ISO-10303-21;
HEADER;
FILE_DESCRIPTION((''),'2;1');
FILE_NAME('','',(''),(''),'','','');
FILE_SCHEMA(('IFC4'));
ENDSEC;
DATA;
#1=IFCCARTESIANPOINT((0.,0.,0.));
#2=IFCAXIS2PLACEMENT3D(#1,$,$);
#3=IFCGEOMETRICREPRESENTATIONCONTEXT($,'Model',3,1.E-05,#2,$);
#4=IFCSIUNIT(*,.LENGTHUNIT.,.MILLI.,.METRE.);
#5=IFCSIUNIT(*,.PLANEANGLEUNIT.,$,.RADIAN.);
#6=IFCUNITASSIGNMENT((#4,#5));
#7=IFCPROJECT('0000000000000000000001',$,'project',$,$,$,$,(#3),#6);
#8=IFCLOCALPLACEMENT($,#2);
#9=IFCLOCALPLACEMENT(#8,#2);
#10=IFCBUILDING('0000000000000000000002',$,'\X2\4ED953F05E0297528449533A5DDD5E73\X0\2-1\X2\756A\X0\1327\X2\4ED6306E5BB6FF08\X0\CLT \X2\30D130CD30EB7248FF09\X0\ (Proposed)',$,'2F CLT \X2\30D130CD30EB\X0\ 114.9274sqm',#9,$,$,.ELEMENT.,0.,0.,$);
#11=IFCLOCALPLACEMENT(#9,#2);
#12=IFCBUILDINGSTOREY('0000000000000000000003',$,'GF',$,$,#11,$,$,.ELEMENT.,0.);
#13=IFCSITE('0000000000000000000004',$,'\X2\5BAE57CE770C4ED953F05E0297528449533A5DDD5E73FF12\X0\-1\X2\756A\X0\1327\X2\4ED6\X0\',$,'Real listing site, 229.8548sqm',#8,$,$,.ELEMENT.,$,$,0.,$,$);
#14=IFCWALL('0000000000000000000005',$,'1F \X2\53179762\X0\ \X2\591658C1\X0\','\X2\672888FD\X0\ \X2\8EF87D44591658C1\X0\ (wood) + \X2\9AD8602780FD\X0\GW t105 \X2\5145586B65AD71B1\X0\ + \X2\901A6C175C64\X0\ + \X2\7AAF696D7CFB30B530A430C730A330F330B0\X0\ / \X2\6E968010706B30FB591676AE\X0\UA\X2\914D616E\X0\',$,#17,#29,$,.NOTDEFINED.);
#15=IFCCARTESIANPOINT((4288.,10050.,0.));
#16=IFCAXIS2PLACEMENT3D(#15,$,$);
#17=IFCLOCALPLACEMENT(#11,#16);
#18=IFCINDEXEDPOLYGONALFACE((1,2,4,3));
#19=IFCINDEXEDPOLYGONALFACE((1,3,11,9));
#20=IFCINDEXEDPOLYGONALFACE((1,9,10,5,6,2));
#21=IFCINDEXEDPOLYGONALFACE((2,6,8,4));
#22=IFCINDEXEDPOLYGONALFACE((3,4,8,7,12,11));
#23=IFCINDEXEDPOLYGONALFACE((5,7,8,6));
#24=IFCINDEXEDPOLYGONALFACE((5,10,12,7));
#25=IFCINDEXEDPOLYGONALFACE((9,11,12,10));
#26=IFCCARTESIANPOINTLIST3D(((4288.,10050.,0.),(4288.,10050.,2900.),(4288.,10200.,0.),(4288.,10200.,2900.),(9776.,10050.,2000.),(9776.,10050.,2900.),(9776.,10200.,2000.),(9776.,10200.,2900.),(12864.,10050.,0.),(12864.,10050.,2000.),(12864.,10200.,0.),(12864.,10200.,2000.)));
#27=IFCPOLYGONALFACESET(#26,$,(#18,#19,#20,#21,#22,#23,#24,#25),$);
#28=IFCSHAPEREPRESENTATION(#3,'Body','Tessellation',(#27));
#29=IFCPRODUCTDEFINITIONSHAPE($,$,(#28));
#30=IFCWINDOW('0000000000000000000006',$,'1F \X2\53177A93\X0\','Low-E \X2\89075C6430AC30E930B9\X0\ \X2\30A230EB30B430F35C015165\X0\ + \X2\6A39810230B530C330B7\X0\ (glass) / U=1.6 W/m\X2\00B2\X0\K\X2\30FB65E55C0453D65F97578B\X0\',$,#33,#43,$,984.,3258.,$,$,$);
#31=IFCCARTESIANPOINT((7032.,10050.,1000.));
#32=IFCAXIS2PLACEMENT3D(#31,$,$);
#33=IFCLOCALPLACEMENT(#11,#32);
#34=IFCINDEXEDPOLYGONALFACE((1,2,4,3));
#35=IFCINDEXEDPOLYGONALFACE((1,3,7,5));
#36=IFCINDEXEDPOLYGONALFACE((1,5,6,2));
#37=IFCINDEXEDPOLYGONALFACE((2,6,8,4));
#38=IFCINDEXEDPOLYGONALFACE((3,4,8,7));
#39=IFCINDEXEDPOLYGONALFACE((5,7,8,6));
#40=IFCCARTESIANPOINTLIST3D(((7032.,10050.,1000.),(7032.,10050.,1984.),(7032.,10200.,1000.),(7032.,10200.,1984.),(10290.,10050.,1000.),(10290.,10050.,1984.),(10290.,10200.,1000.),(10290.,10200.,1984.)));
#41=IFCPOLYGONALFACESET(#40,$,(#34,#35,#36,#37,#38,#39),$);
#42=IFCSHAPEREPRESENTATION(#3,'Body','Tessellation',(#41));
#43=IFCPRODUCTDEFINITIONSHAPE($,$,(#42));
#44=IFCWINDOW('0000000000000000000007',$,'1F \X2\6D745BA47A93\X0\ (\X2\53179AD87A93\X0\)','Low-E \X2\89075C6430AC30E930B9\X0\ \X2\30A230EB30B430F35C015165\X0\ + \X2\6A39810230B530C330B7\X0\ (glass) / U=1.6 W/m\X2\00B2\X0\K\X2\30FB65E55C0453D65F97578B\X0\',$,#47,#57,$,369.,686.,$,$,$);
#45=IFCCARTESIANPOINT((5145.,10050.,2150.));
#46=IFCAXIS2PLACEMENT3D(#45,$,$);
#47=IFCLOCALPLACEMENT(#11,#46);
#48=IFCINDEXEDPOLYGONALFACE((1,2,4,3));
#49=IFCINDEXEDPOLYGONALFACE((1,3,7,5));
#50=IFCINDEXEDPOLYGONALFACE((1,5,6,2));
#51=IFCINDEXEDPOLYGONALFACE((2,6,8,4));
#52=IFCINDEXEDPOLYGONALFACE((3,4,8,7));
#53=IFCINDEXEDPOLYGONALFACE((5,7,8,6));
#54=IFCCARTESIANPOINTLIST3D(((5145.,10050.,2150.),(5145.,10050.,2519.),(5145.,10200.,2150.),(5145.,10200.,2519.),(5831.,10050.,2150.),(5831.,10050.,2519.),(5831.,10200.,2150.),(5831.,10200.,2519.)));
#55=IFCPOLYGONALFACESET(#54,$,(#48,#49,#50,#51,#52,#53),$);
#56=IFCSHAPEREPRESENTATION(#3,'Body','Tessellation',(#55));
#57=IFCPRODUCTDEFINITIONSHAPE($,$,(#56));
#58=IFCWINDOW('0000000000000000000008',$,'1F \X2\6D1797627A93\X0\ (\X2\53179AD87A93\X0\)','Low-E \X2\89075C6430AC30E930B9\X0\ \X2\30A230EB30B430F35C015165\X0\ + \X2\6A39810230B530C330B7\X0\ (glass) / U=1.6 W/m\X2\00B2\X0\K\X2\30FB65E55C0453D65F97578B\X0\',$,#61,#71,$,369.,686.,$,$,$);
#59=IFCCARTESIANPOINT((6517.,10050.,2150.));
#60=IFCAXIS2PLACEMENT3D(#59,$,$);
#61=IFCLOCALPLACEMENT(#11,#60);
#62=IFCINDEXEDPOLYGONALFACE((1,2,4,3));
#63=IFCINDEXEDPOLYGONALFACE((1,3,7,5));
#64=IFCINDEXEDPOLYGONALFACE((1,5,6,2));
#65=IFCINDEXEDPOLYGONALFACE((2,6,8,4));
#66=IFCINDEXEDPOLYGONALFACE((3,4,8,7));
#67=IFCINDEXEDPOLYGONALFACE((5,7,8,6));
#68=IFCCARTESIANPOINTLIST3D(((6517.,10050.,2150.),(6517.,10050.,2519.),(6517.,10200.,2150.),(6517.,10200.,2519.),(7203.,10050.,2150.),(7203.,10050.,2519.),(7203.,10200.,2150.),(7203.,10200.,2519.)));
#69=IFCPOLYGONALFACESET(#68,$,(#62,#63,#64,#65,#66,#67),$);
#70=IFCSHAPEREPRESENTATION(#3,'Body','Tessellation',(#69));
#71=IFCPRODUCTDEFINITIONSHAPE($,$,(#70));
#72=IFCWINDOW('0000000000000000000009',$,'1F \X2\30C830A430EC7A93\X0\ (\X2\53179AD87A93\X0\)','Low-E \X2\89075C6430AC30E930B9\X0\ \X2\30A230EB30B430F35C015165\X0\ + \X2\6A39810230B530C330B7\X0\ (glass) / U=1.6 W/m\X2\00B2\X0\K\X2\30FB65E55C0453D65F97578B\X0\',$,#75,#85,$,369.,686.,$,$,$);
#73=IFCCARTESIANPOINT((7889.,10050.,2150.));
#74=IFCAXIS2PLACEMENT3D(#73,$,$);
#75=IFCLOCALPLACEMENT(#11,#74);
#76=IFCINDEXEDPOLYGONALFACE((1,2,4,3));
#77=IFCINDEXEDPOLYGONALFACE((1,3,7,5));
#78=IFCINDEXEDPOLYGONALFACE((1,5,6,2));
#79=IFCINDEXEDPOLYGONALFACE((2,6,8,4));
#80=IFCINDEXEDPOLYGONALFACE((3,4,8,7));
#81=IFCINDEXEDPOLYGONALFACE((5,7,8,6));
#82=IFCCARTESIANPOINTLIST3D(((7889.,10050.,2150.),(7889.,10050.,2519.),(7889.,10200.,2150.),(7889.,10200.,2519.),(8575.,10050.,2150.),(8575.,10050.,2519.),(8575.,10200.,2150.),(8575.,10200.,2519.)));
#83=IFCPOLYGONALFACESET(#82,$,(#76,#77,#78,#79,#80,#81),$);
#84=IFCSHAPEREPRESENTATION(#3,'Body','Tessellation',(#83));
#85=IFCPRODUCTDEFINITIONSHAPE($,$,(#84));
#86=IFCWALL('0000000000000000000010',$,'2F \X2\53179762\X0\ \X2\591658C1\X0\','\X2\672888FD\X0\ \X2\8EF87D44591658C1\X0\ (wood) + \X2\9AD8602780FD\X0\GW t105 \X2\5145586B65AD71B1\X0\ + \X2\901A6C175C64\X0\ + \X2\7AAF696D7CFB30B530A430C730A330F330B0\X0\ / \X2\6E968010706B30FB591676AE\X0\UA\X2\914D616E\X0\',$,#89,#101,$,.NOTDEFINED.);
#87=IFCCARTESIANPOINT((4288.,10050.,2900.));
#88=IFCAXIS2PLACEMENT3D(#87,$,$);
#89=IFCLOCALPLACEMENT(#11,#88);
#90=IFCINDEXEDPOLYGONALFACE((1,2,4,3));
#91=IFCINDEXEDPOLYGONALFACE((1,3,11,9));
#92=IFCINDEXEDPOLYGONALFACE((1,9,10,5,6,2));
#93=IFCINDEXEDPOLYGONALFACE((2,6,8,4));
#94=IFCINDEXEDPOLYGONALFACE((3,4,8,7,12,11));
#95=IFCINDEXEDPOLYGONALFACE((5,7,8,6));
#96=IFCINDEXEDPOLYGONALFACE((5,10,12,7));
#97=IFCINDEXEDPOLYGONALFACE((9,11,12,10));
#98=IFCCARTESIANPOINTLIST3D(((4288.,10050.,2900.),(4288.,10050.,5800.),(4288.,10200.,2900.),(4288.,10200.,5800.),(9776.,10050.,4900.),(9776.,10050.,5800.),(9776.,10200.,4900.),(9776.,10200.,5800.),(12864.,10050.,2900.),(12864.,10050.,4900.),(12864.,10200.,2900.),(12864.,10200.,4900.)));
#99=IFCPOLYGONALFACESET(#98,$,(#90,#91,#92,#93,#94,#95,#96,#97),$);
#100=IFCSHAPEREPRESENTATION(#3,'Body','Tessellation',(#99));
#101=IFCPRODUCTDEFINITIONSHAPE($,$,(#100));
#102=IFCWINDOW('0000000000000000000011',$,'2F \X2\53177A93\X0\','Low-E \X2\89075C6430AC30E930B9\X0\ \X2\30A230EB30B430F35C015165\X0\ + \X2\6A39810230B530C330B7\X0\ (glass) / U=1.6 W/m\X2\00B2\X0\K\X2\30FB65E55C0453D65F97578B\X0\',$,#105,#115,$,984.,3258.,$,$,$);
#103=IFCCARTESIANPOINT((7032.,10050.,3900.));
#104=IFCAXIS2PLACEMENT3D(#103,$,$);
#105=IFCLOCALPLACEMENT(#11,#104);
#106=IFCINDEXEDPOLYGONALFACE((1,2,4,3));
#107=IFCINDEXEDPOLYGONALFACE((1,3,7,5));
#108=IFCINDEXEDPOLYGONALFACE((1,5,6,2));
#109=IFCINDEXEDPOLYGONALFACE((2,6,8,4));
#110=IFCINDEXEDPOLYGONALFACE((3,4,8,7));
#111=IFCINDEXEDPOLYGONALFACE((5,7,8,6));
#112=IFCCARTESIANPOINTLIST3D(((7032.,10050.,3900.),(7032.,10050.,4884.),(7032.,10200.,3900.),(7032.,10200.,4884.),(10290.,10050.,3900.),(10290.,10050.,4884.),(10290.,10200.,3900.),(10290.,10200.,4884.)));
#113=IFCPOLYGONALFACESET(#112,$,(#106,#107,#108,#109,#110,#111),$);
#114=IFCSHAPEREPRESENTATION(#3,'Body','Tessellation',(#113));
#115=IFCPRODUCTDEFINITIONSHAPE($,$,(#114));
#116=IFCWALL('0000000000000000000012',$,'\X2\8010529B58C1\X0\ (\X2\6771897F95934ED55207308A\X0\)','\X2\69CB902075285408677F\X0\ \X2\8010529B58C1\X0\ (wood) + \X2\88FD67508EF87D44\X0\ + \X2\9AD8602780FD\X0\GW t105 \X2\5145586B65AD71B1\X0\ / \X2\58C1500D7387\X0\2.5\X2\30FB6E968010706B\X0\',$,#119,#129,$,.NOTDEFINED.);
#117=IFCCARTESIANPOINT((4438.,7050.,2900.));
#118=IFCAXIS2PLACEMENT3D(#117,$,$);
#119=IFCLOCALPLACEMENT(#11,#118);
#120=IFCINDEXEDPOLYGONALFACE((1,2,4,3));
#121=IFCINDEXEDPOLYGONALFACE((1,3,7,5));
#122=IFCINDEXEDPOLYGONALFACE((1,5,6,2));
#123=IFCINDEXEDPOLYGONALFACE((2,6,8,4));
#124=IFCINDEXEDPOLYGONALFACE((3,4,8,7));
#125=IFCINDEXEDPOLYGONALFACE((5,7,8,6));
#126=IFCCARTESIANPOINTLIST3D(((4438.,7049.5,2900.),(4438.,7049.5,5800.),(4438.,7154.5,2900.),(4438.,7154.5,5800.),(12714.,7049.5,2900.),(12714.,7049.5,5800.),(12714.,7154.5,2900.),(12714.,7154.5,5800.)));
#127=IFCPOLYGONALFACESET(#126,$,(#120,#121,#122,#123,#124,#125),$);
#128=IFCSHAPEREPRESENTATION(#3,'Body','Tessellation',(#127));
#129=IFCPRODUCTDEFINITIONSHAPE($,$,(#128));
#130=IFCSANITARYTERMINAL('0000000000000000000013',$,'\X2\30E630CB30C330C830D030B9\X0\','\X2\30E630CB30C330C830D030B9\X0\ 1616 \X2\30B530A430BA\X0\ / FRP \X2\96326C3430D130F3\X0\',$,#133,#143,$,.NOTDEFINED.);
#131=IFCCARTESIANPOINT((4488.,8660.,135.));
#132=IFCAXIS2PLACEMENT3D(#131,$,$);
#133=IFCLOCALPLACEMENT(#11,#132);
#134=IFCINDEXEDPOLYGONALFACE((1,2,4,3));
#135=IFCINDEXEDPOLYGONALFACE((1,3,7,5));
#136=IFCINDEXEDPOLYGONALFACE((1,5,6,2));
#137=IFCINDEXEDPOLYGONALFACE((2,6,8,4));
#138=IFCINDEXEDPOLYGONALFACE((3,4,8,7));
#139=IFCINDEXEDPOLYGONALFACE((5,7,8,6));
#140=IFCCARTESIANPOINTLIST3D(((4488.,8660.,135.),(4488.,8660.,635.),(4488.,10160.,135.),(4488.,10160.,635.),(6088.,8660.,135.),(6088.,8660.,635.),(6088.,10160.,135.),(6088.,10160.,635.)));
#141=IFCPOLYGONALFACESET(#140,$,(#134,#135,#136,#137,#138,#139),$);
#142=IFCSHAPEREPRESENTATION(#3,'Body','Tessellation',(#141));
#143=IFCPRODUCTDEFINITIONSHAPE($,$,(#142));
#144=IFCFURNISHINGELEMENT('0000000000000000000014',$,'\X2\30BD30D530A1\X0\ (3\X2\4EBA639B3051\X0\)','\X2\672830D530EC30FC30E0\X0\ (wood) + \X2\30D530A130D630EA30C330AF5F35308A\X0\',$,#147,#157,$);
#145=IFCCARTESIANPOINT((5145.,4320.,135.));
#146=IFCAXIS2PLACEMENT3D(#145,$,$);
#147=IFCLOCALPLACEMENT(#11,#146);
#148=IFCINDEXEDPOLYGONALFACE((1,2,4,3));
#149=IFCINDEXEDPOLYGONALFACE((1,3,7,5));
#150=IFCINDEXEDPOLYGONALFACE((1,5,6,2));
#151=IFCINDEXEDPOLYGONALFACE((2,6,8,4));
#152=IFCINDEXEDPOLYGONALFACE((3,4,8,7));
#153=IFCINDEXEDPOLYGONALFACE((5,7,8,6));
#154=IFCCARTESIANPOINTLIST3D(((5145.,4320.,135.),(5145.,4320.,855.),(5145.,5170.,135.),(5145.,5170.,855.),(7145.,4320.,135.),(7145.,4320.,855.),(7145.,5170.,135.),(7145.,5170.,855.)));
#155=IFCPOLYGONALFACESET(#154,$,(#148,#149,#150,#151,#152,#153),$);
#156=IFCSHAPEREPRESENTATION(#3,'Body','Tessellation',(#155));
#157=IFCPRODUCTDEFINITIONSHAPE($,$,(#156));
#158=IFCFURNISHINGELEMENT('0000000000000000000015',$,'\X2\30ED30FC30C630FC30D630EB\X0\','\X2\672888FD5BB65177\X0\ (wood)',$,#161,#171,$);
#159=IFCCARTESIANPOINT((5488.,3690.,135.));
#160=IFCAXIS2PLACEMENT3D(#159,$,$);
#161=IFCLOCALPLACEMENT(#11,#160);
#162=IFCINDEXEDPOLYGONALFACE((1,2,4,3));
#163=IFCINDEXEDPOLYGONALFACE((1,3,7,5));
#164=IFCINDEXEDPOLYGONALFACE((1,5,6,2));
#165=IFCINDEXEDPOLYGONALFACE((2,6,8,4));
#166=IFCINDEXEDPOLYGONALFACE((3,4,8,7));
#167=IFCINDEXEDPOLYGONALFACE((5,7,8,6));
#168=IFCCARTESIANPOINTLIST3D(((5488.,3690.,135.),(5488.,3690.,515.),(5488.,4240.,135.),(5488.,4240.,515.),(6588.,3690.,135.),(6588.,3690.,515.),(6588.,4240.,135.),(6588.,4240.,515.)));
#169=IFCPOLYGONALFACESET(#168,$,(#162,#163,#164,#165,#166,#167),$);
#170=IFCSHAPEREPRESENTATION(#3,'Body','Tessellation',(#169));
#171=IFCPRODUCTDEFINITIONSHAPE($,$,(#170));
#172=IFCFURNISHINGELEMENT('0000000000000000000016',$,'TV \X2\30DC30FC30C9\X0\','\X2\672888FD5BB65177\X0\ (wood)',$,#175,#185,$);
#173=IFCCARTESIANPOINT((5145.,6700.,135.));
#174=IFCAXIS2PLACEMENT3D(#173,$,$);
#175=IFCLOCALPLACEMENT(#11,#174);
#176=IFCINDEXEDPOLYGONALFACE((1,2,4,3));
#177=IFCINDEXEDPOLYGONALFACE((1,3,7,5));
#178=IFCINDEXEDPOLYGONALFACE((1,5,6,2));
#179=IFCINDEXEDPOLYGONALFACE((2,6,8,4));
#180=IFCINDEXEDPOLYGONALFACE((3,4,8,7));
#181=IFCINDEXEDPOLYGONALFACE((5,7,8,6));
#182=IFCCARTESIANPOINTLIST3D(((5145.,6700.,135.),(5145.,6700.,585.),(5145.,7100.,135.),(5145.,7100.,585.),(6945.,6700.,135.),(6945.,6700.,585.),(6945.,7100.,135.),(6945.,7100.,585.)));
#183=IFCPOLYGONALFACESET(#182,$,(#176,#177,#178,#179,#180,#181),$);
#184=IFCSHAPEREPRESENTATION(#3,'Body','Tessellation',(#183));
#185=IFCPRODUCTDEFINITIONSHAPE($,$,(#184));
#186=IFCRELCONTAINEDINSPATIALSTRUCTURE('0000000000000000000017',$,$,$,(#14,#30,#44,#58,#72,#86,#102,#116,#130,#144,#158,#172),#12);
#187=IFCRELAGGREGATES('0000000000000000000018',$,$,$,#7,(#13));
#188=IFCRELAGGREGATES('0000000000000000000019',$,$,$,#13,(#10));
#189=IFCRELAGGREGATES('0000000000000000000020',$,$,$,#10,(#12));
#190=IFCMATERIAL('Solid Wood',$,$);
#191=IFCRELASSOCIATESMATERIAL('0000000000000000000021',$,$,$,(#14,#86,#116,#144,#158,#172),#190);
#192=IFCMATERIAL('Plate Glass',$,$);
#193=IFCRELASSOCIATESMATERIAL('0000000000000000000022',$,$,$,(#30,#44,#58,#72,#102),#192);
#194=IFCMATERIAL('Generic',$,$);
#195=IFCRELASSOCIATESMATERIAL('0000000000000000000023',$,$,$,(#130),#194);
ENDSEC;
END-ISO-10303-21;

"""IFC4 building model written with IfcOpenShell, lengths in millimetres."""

from ifc_helpers import new_model, si_unit, frame, frame_2d, origin, place, context, project, spatial, rectangle, extrude, material, element, fill, save


model = new_model("IFC4")

# Units and contexts
model_context = context("Model", 3, precision=1e-05, world=origin())
ifc_project = project(units=[si_unit("LENGTHUNIT", "METRE", prefix="MILLI"), si_unit("PLANEANGLEUNIT", "RADIAN")], contexts=[model_context])

# Site, building, storey
site_placement = place(None, origin())
site = spatial("IfcSite", under=ifc_project, at=site_placement, Name="宮城県仙台市青葉区川平２-1番1327他", ObjectType="Real listing site, 229.8548sqm", CompositionType="ELEMENT", RefElevation=0.0)
building_placement = place(site_placement, origin())
building = spatial("IfcBuilding", under=site, at=building_placement, Name="仙台市青葉区川平2-1番1327他の家（CLT パネル版） (Proposed)", ObjectType="2F CLT パネル 114.9274sqm", CompositionType="ELEMENT", ElevationOfRefHeight=0.0, ElevationOfTerrain=0.0)
storey_placement = place(building_placement, origin())
storey = spatial("IfcBuildingStorey", under=building, at=storey_placement, Name="GF", CompositionType="ELEMENT", Elevation=0.0)

# Wall, openings, windows
ifc_material_1 = material(Name="Solid Wood")
wall_1_placement = place(storey_placement, frame((4288.0, 10050.0, 0.0)))
wall_1 = element("IfcWall", 1, at=wall_1_placement, inside=storey, material=ifc_material_1, Name="1F 北面 外壁", Description="木製 軸組外壁 (wood) + 高性能GW t105 充填断熱 + 通気層 + 窯業系サイディング / 準耐火・外皮UA配慮", PredefinedType="NOTDEFINED", context=model_context, shape_type="SweptSolid", body=[
    extrude(rectangle(XDim=8576.0, YDim=150.0, at=frame_2d((4288.0, 75.0))), frame((4288.0, 10050.0, 0.0)), (0.0, 0.0, 1.0), 2900.0),
])
opening_1_placement = place(storey_placement, frame((7032.0, 10050.0, 1000.0)))
opening_1 = element("IfcOpeningElement", 2, at=opening_1_placement, cuts=wall_1, PredefinedType="NOTDEFINED", context=model_context, shape_type="SweptSolid", body=[
    extrude(rectangle(XDim=3258.0, YDim=150.0, at=frame_2d((1629.0, 75.0))), frame((7032.0, 10050.0, 1000.0)), (0.0, 0.0, 1.0), 984.0),
])
opening_2_placement = place(storey_placement, frame((5145.0, 10050.0, 2150.0)))
opening_2 = element("IfcOpeningElement", 3, at=opening_2_placement, cuts=wall_1, PredefinedType="NOTDEFINED", context=model_context, shape_type="SweptSolid", body=[
    extrude(rectangle(XDim=686.0, YDim=150.0, at=frame_2d((343.0, 75.0))), frame((5145.0, 10050.0, 2150.0)), (0.0, 0.0, 1.0), 369.0),
])
opening_3_placement = place(storey_placement, frame((6517.0, 10050.0, 2150.0)))
opening_3 = element("IfcOpeningElement", 4, at=opening_3_placement, cuts=wall_1, PredefinedType="NOTDEFINED", context=model_context, shape_type="SweptSolid", body=[
    extrude(rectangle(XDim=686.0, YDim=150.0, at=frame_2d((343.0, 75.0))), frame((6517.0, 10050.0, 2150.0)), (0.0, 0.0, 1.0), 369.0),
])
opening_4_placement = place(storey_placement, frame((7889.0, 10050.0, 2150.0)))
opening_4 = element("IfcOpeningElement", 5, at=opening_4_placement, cuts=wall_1, PredefinedType="NOTDEFINED", context=model_context, shape_type="SweptSolid", body=[
    extrude(rectangle(XDim=686.0, YDim=150.0, at=frame_2d((343.0, 75.0))), frame((7889.0, 10050.0, 2150.0)), (0.0, 0.0, 1.0), 369.0),
])
ifc_material_2 = material(Name="Plate Glass")
window_1_placement = place(storey_placement, frame((7032.0, 10050.0, 1000.0)))
window_1 = element("IfcWindow", 6, at=window_1_placement, inside=storey, material=ifc_material_2, Name="1F 北窓", Description="Low-E 複層ガラス アルゴン封入 + 樹脂サッシ (glass) / U=1.6 W/m²K・日射取得型", OverallHeight=984.0, OverallWidth=3258.0, context=model_context, shape_type="SweptSolid", body=[
    extrude(rectangle(XDim=3258.0, YDim=150.0, at=frame_2d((1629.0, 75.0))), frame((7032.0, 10050.0, 1000.0)), (0.0, 0.0, 1.0), 984.0),
])
fill(opening_1, window_1)
window_2_placement = place(storey_placement, frame((5145.0, 10050.0, 2150.0)))
window_2 = element("IfcWindow", 7, at=window_2_placement, inside=storey, material=ifc_material_2, Name="1F 浴室窓 (北高窓)", Description="Low-E 複層ガラス アルゴン封入 + 樹脂サッシ (glass) / U=1.6 W/m²K・日射取得型", OverallHeight=369.0, OverallWidth=686.0, context=model_context, shape_type="SweptSolid", body=[
    extrude(rectangle(XDim=686.0, YDim=150.0, at=frame_2d((343.0, 75.0))), frame((5145.0, 10050.0, 2150.0)), (0.0, 0.0, 1.0), 369.0),
])
fill(opening_2, window_2)
window_3_placement = place(storey_placement, frame((6517.0, 10050.0, 2150.0)))
window_3 = element("IfcWindow", 8, at=window_3_placement, inside=storey, material=ifc_material_2, Name="1F 洗面窓 (北高窓)", Description="Low-E 複層ガラス アルゴン封入 + 樹脂サッシ (glass) / U=1.6 W/m²K・日射取得型", OverallHeight=369.0, OverallWidth=686.0, context=model_context, shape_type="SweptSolid", body=[
    extrude(rectangle(XDim=686.0, YDim=150.0, at=frame_2d((343.0, 75.0))), frame((6517.0, 10050.0, 2150.0)), (0.0, 0.0, 1.0), 369.0),
])
fill(opening_3, window_3)
window_4_placement = place(storey_placement, frame((7889.0, 10050.0, 2150.0)))
window_4 = element("IfcWindow", 9, at=window_4_placement, inside=storey, material=ifc_material_2, Name="1F トイレ窓 (北高窓)", Description="Low-E 複層ガラス アルゴン封入 + 樹脂サッシ (glass) / U=1.6 W/m²K・日射取得型", OverallHeight=369.0, OverallWidth=686.0, context=model_context, shape_type="SweptSolid", body=[
    extrude(rectangle(XDim=686.0, YDim=150.0, at=frame_2d((343.0, 75.0))), frame((7889.0, 10050.0, 2150.0)), (0.0, 0.0, 1.0), 369.0),
])
fill(opening_4, window_4)

# Wall, opening, window
wall_2_placement = place(storey_placement, frame((4288.0, 10050.0, 2900.0)))
wall_2 = element("IfcWall", 10, at=wall_2_placement, inside=storey, material=ifc_material_1, Name="2F 北面 外壁", Description="木製 軸組外壁 (wood) + 高性能GW t105 充填断熱 + 通気層 + 窯業系サイディング / 準耐火・外皮UA配慮", PredefinedType="NOTDEFINED", context=model_context, shape_type="SweptSolid", body=[
    extrude(rectangle(XDim=8576.0, YDim=150.0, at=frame_2d((4288.0, 75.0))), frame((4288.0, 10050.0, 2900.0)), (0.0, 0.0, 1.0), 2900.0),
])
opening_5_placement = place(storey_placement, frame((7032.0, 10050.0, 3900.0)))
opening_5 = element("IfcOpeningElement", 11, at=opening_5_placement, cuts=wall_2, PredefinedType="NOTDEFINED", context=model_context, shape_type="SweptSolid", body=[
    extrude(rectangle(XDim=3258.0, YDim=150.0, at=frame_2d((1629.0, 75.0))), frame((7032.0, 10050.0, 3900.0)), (0.0, 0.0, 1.0), 984.0),
])
window_5_placement = place(storey_placement, frame((7032.0, 10050.0, 3900.0)))
window_5 = element("IfcWindow", 12, at=window_5_placement, inside=storey, material=ifc_material_2, Name="2F 北窓", Description="Low-E 複層ガラス アルゴン封入 + 樹脂サッシ (glass) / U=1.6 W/m²K・日射取得型", OverallHeight=984.0, OverallWidth=3258.0, context=model_context, shape_type="SweptSolid", body=[
    extrude(rectangle(XDim=3258.0, YDim=150.0, at=frame_2d((1629.0, 75.0))), frame((7032.0, 10050.0, 3900.0)), (0.0, 0.0, 1.0), 984.0),
])
fill(opening_5, window_5)

# Wall
wall_3_placement = place(storey_placement, frame((4438.0, 7050.0, 2900.0)))
element("IfcWall", 13, at=wall_3_placement, inside=storey, material=ifc_material_1, Name="耐力壁 (東西間仕切り)", Description="構造用合板 耐力壁 (wood) + 製材軸組 + 高性能GW t105 充填断熱 / 壁倍率2.5・準耐火", PredefinedType="NOTDEFINED", context=model_context, shape_type="SweptSolid", body=[
    extrude(rectangle(XDim=8276.0, YDim=105.0, at=frame_2d((4138.0, 52.0))), frame((4438.0, 7050.0, 2900.0)), (0.0, 0.0, 1.0), 2900.0),
])

# Sanitary terminal
ifc_material_3 = material(Name="Generic")
sanitary_terminal_placement = place(storey_placement, frame((4488.0, 8660.0, 135.0)))
element("IfcSanitaryTerminal", 14, at=sanitary_terminal_placement, inside=storey, material=ifc_material_3, Name="ユニットバス", Description="ユニットバス 1616 サイズ / FRP 防水パン", PredefinedType="NOTDEFINED", context=model_context, shape_type="SweptSolid", body=[
    extrude(rectangle(XDim=1600.0, YDim=1500.0, at=frame_2d((800.0, 750.0))), frame((4488.0, 8660.0, 135.0)), (0.0, 0.0, 1.0), 500.0),
])

# Furnishing elements
furnishing_1_placement = place(storey_placement, frame((5145.0, 4320.0, 135.0)))
element("IfcFurnishingElement", 15, at=furnishing_1_placement, inside=storey, material=ifc_material_1, Name="ソファ (3人掛け)", Description="木フレーム (wood) + ファブリック張り", context=model_context, shape_type="SweptSolid", body=[
    extrude(rectangle(XDim=2000.0, YDim=850.0, at=frame_2d((1000.0, 425.0))), frame((5145.0, 4320.0, 135.0)), (0.0, 0.0, 1.0), 720.0),
])
furnishing_2_placement = place(storey_placement, frame((5488.0, 3690.0, 135.0)))
element("IfcFurnishingElement", 16, at=furnishing_2_placement, inside=storey, material=ifc_material_1, Name="ローテーブル", Description="木製家具 (wood)", context=model_context, shape_type="SweptSolid", body=[
    extrude(rectangle(XDim=1100.0, YDim=550.0, at=frame_2d((550.0, 275.0))), frame((5488.0, 3690.0, 135.0)), (0.0, 0.0, 1.0), 380.0),
])
furnishing_3_placement = place(storey_placement, frame((5145.0, 6700.0, 135.0)))
element("IfcFurnishingElement", 17, at=furnishing_3_placement, inside=storey, material=ifc_material_1, Name="TV ボード", Description="木製家具 (wood)", context=model_context, shape_type="SweptSolid", body=[
    extrude(rectangle(XDim=1800.0, YDim=400.0, at=frame_2d((900.0, 200.0))), frame((5145.0, 6700.0, 135.0)), (0.0, 0.0, 1.0), 450.0),
])

save(model, "model.ifc")
